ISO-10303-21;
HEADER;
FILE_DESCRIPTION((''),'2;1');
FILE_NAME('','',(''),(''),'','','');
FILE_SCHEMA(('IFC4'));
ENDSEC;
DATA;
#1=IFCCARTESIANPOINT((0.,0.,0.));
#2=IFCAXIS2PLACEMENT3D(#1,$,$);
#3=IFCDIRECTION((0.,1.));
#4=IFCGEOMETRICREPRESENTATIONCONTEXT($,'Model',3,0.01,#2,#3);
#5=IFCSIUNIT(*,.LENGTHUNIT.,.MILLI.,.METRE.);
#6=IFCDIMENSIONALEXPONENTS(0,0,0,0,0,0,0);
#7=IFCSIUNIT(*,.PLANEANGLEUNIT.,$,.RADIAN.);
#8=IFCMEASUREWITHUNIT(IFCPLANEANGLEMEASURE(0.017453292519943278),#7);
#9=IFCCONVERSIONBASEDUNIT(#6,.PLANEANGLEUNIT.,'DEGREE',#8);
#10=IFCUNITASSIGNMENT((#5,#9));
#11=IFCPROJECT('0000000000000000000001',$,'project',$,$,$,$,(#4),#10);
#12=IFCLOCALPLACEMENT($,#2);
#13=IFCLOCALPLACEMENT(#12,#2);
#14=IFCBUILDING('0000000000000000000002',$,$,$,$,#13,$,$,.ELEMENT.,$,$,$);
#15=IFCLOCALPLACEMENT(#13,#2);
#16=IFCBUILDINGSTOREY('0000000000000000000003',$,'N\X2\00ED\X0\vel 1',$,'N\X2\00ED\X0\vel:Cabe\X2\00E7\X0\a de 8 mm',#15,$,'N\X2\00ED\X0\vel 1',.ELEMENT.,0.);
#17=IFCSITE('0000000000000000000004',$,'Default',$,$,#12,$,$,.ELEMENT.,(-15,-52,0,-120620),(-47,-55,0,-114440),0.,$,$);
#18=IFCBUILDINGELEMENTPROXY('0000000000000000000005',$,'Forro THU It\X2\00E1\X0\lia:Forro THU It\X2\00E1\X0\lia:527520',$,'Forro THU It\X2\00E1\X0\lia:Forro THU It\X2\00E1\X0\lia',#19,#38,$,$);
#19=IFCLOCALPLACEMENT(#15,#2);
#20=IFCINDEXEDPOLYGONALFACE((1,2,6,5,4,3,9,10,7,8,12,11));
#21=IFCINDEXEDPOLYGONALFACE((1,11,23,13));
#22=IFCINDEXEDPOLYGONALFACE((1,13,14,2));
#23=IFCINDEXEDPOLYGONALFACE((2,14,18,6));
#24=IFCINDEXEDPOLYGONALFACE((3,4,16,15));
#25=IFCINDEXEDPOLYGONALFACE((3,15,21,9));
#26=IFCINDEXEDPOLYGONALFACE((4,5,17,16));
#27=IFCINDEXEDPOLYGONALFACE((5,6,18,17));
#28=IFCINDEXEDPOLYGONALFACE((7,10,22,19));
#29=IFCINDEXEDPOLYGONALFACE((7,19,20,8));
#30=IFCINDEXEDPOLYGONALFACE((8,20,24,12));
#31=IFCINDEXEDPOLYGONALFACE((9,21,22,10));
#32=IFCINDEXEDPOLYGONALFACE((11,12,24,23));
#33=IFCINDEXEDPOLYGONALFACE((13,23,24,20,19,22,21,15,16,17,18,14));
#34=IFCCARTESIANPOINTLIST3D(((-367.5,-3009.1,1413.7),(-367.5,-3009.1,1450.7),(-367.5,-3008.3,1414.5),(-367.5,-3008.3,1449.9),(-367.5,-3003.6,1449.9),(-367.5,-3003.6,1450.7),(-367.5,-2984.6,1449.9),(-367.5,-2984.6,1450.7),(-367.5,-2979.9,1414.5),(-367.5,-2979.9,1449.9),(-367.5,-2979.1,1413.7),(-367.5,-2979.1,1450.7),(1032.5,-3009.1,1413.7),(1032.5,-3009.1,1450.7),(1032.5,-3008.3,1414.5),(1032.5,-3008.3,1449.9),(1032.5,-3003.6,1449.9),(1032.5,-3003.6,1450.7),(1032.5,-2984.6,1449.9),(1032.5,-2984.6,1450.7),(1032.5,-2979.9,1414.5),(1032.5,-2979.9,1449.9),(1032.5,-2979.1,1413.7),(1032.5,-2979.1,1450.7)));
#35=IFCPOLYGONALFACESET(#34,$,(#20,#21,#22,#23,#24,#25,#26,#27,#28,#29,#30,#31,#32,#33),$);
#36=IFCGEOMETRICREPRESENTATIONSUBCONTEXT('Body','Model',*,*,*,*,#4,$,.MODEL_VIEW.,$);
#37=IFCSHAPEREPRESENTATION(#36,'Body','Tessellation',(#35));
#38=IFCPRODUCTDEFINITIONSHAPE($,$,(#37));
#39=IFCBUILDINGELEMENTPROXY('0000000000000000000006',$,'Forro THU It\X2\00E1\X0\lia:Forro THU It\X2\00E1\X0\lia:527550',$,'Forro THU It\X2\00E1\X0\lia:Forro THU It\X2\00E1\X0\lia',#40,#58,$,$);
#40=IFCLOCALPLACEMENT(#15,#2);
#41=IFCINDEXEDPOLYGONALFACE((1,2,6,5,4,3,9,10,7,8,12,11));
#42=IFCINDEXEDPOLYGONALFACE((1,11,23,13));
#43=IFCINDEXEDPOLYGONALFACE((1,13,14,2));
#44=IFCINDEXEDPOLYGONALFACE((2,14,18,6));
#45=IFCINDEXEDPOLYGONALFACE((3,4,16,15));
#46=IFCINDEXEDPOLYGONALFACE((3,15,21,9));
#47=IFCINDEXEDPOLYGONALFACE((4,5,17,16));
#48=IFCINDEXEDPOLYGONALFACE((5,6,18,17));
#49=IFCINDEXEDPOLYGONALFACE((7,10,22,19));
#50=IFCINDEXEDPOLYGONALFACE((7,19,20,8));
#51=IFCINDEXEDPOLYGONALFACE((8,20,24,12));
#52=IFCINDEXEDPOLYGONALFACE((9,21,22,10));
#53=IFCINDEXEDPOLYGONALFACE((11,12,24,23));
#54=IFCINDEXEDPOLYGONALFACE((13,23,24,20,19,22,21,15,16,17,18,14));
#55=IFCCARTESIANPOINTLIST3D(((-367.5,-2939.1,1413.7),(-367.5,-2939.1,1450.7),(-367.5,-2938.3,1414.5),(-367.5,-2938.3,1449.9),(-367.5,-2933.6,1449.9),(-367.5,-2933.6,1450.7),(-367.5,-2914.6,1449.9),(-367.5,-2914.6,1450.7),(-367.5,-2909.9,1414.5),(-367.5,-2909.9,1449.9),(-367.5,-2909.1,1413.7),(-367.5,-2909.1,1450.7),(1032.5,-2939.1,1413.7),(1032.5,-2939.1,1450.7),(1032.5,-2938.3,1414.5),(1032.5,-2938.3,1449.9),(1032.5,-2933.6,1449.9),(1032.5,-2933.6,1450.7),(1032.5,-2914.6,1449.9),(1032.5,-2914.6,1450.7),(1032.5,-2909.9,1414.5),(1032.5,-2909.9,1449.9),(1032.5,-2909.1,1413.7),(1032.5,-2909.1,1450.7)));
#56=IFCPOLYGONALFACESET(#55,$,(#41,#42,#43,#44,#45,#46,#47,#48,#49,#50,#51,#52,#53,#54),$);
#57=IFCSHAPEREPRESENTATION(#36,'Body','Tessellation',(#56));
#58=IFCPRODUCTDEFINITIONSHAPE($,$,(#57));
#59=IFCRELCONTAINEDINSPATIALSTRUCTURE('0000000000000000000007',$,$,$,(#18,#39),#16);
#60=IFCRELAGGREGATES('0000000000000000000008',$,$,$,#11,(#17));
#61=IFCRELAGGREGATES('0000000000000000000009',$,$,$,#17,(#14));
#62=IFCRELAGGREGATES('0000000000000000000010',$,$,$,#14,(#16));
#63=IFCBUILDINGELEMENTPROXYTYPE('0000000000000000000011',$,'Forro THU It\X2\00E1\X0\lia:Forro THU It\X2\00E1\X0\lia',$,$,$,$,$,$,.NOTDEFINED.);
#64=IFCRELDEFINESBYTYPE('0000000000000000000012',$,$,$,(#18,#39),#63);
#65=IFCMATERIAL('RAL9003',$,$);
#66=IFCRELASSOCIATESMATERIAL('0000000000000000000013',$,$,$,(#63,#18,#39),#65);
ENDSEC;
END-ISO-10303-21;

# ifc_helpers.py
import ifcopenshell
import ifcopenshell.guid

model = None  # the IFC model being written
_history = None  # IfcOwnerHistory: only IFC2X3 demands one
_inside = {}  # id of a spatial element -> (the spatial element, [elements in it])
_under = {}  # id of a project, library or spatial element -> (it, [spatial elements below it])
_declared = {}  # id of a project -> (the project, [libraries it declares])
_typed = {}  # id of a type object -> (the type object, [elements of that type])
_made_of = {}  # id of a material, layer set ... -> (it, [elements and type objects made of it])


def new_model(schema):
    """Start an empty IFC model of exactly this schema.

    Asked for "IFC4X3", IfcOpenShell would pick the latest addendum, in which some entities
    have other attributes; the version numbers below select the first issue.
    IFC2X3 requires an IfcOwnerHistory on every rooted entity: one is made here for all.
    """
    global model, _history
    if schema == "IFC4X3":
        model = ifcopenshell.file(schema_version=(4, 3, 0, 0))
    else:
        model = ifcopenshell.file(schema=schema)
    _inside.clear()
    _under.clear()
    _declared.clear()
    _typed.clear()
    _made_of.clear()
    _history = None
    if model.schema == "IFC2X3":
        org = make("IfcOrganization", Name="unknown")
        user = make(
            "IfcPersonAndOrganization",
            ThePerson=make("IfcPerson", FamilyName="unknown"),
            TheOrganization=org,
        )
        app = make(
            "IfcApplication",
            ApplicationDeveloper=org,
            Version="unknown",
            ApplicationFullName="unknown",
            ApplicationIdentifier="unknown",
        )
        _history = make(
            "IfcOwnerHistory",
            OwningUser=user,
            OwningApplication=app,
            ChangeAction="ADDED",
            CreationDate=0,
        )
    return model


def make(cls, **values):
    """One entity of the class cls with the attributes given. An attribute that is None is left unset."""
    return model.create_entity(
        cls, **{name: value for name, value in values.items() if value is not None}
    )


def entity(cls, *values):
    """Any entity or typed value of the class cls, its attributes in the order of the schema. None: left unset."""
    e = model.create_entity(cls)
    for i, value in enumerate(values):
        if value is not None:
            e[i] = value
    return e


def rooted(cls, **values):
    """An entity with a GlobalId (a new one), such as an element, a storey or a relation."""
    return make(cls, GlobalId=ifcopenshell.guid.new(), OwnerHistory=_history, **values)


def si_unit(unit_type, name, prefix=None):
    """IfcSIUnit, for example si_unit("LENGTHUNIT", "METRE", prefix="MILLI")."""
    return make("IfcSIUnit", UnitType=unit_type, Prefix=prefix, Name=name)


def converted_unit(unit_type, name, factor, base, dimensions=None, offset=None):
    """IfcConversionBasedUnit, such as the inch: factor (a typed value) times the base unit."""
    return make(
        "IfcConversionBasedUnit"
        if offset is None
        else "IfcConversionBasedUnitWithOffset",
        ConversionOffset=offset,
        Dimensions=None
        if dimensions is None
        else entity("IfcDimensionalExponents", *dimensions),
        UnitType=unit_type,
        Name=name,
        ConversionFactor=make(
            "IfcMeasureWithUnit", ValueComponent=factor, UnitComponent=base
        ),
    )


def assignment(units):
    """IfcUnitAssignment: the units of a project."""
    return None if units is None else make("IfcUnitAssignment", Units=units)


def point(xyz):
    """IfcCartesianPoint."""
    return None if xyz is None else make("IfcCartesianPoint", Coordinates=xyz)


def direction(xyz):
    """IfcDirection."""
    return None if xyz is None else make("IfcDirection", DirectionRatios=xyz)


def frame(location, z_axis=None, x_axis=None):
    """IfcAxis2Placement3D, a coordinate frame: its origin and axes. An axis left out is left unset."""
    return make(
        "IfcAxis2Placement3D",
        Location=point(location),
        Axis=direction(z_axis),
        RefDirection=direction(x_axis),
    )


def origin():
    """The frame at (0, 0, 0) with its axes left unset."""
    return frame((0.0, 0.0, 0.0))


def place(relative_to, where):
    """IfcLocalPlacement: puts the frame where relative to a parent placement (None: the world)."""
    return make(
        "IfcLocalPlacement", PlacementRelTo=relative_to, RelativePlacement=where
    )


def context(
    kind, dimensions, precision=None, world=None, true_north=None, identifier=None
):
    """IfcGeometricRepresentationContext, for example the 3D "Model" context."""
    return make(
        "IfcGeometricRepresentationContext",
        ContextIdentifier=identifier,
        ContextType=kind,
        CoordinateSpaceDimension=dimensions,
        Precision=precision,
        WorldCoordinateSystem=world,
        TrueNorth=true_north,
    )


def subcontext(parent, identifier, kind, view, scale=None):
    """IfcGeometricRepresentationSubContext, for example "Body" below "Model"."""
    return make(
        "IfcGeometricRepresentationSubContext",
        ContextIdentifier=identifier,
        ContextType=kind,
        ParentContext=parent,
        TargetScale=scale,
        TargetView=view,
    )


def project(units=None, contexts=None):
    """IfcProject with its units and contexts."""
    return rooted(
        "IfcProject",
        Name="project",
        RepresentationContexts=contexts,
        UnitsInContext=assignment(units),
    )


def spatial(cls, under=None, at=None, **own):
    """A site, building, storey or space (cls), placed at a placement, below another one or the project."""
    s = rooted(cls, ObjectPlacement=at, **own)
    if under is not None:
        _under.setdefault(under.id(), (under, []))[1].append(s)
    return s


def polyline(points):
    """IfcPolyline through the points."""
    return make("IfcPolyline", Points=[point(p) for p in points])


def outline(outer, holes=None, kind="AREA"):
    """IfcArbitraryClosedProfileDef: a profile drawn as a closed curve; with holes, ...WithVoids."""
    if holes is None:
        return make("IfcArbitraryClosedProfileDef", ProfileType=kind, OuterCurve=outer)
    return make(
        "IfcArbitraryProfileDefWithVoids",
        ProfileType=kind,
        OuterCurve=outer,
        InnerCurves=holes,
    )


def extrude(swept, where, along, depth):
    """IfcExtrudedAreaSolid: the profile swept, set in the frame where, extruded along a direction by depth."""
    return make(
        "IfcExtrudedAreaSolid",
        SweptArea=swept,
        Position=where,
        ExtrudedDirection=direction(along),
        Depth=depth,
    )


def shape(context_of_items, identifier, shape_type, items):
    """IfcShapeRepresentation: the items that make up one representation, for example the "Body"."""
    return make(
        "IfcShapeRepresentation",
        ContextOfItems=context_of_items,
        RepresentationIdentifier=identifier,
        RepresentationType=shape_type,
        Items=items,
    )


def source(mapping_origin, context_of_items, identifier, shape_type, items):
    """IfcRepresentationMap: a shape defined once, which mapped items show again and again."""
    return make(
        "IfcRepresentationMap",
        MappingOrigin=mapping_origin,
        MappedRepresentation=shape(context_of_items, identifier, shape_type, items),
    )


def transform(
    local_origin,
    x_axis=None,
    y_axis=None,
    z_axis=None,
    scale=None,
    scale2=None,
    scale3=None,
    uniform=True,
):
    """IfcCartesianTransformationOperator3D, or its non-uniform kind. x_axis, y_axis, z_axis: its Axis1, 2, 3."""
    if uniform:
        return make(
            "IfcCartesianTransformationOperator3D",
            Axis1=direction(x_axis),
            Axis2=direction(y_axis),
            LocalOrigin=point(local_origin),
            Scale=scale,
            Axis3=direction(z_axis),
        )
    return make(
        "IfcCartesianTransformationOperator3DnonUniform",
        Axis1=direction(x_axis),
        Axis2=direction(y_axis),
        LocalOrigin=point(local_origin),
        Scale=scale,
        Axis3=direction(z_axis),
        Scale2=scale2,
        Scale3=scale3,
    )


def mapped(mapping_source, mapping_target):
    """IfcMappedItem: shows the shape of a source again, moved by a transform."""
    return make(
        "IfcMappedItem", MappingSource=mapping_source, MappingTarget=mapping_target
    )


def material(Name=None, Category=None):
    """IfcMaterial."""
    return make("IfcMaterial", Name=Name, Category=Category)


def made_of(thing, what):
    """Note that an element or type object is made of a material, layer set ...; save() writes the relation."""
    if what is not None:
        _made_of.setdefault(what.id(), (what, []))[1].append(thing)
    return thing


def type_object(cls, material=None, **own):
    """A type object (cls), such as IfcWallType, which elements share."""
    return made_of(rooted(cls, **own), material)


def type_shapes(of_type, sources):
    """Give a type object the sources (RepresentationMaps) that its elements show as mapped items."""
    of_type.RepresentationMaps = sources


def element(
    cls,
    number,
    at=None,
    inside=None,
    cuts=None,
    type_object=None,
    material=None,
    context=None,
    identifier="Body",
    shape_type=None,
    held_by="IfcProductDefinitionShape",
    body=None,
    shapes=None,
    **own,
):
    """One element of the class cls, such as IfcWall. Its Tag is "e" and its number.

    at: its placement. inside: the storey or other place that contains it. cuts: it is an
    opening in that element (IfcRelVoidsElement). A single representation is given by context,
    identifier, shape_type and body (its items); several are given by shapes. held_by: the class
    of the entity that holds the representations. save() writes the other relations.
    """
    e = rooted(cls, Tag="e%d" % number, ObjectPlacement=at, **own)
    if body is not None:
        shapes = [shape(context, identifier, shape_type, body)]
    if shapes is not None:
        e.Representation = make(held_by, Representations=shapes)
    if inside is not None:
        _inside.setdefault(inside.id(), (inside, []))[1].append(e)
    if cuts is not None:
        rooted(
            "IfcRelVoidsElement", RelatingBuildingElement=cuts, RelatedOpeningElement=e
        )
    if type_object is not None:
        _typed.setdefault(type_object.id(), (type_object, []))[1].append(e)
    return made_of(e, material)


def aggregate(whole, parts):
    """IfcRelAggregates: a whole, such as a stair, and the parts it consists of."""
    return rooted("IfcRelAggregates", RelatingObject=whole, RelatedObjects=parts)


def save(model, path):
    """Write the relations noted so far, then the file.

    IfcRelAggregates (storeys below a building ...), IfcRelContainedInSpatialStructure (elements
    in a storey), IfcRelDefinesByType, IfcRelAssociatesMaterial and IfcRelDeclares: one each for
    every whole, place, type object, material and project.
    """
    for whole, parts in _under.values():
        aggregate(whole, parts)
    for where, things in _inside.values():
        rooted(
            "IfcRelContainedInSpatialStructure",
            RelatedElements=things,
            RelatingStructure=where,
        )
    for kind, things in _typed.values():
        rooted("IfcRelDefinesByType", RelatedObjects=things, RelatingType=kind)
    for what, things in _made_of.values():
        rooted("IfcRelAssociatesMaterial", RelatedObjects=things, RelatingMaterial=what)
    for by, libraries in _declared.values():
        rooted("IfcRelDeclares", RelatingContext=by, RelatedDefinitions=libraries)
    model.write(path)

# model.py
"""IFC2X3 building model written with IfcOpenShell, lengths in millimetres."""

from ifc_helpers import new_model, entity, si_unit, converted_unit, direction, frame, origin, place, context, subcontext, project, spatial, polyline, outline, extrude, source, transform, mapped, material, type_object, type_shapes, element, save


model = new_model("IFC2X3")

# Units and contexts
model_context = context("Model", 3, precision=0.01, world=origin(), true_north=direction((0.0, 1.0)))
body_context = subcontext(model_context, "Body", "Model", "MODEL_VIEW")
ifc_project = project(units=[si_unit("LENGTHUNIT", "METRE", prefix="MILLI"), converted_unit("PLANEANGLEUNIT", "DEGREE", entity("IfcPlaneAngleMeasure", 0.017453292519943278), si_unit("PLANEANGLEUNIT", "RADIAN"), dimensions=[0, 0, 0, 0, 0, 0, 0])], contexts=[model_context])

# Site, building, storey
site_placement = place(None, origin())
site = spatial("IfcSite", under=ifc_project, at=site_placement, Name="Default", CompositionType="ELEMENT", RefLatitude=(-15, -52, 0, -120620), RefLongitude=(-47, -55, 0, -114440), RefElevation=0.0)
building_placement = place(site_placement, origin())
building = spatial("IfcBuilding", under=site, at=building_placement, CompositionType="ELEMENT")
storey_placement = place(building_placement, origin())
storey = spatial("IfcBuildingStorey", under=building, at=storey_placement, Name="Nível 1", ObjectType="Nível:Cabeça de 8 mm", LongName="Nível 1", CompositionType="ELEMENT", Elevation=0.0)

# Building element proxies
ifc_material = material(Name="RAL9003")
building_element_proxy_type_1 = type_object("IfcBuildingElementProxyType", Name="Forro THU Itália:Forro THU Itália", PredefinedType="NOTDEFINED", material=ifc_material)
shared_shape_1 = source(origin(), body_context, "Body", "SweptSolid", [
    extrude(outline(polyline([(-12.5, -15.0), (24.5, -15.0), (24.5, 15.0), (-12.5, 15.0), (-12.5, 9.5), (-11.7, 9.5), (-11.7, 14.2), (23.7, 14.2), (23.7, -14.2), (-11.7, -14.2), (-11.7, -9.5), (-12.5, -9.5), (-12.5, -15.0)])), frame((0.0, 15.0, -12.5), z_axis=(1.0, 0.0, 0.0), x_axis=(0.0, 0.0, -1.0)), (0.0, 0.0, 1.0), 1400.0),
])
type_shapes(building_element_proxy_type_1, [shared_shape_1])
for number, where, name in (
    (1, (-367.5, -3009.1, 1450.7), "Forro THU Itália:Forro THU Itália:527520"),
    (2, (-367.5, -2939.1, 1450.7), "Forro THU Itália:Forro THU Itália:527550"),
):
    element("IfcBuildingElementProxy", number, at=place(storey_placement, frame(where)), inside=storey, type_object=building_element_proxy_type_1, material=ifc_material, Name=name, ObjectType="Forro THU Itália:Forro THU Itália", context=body_context, shape_type="MappedRepresentation", body=[
        mapped(shared_shape_1, transform((0.0, 0.0, 0.0), scale=1.0)),
    ])

save(model, "model.ifc")
